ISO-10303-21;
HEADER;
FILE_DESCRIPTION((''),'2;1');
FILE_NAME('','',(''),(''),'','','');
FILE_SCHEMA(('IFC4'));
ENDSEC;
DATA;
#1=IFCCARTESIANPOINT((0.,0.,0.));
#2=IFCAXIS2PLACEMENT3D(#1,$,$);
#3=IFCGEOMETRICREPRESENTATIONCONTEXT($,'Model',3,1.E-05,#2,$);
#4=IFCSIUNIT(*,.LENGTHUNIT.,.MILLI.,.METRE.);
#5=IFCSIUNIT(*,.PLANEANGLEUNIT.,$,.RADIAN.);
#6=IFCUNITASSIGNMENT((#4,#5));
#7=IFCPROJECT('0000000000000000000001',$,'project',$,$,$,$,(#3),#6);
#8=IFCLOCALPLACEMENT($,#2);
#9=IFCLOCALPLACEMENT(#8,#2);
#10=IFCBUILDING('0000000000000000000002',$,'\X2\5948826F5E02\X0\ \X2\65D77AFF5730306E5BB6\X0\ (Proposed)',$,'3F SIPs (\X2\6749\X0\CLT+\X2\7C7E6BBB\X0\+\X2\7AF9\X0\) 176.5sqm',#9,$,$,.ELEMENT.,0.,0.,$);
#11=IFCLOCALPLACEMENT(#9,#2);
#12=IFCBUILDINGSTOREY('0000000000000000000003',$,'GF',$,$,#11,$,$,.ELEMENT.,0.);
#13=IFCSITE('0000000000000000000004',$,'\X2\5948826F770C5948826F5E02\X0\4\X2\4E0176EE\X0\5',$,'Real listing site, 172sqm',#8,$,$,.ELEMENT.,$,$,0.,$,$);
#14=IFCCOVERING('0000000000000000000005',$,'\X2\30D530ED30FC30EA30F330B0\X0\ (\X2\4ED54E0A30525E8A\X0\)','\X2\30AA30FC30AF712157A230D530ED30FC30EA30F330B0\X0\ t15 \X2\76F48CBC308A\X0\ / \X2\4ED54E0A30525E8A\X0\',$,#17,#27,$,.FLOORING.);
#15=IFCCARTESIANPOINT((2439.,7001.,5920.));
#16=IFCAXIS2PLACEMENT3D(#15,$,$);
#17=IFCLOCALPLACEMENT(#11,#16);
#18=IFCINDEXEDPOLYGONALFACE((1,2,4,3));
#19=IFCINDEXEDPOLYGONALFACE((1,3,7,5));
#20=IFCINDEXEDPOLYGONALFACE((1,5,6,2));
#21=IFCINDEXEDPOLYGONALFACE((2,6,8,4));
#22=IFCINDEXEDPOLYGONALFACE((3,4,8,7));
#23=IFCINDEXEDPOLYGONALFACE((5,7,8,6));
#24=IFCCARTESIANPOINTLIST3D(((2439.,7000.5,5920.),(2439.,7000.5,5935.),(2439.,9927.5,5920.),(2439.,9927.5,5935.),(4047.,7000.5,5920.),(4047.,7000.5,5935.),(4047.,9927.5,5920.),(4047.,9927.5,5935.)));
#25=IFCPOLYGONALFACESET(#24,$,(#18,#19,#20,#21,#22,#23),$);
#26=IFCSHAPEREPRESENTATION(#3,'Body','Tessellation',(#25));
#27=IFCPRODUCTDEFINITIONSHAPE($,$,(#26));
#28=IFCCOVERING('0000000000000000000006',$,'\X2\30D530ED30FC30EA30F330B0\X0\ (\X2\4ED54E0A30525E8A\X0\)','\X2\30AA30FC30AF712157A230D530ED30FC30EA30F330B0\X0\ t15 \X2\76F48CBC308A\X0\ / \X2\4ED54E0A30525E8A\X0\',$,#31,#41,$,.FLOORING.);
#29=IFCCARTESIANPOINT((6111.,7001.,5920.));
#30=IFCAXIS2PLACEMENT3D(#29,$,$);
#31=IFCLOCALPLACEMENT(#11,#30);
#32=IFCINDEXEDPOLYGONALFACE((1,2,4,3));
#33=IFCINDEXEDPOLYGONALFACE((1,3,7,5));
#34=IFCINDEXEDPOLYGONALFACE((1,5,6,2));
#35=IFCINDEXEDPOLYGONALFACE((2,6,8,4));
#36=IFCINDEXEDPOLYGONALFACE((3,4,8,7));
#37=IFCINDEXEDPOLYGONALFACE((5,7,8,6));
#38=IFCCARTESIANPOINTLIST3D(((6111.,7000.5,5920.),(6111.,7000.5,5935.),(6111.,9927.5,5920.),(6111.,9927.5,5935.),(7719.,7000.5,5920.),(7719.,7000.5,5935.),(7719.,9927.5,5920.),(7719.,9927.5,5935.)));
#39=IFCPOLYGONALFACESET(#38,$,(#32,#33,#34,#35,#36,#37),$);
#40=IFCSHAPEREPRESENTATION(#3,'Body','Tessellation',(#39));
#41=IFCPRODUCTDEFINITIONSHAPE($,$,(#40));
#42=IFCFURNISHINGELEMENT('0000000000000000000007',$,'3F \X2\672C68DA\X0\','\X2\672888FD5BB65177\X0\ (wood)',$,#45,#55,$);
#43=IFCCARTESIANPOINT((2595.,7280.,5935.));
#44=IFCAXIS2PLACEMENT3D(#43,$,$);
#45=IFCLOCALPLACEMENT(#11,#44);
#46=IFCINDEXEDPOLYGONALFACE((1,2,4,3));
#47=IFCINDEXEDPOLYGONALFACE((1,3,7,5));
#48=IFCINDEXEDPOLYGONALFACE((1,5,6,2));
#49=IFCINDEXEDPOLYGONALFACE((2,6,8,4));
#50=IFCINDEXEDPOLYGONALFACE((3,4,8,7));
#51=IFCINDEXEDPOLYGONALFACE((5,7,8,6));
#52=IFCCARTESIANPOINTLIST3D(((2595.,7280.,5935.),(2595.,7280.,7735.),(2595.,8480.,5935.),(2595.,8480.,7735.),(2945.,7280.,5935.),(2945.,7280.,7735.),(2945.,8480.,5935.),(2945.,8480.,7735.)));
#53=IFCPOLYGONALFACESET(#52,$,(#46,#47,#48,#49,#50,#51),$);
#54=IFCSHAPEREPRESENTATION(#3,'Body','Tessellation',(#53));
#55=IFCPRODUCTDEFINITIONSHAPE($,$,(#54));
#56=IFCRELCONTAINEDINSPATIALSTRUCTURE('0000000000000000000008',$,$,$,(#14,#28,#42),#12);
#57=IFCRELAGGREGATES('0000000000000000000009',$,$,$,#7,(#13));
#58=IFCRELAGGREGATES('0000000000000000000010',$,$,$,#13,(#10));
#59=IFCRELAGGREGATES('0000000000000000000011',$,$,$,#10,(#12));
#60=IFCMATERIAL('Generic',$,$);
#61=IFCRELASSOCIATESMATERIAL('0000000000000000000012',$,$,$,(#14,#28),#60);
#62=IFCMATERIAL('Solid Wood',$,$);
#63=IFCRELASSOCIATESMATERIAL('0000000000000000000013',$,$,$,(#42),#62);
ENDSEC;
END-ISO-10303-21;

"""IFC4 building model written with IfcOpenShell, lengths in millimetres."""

from ifc_helpers import new_model, si_unit, frame, frame_2d, origin, place, context, project, spatial, rectangle, extrude, material, element, save


model = new_model("IFC4")

# Units and contexts
model_context = context("Model", 3, precision=1e-05, world=origin())
ifc_project = project(units=[si_unit("LENGTHUNIT", "METRE", prefix="MILLI"), si_unit("PLANEANGLEUNIT", "RADIAN")], contexts=[model_context])

# Site, building, storey
site_placement = place(None, origin())
site = spatial("IfcSite", under=ifc_project, at=site_placement, Name="奈良県奈良市4丁目5", ObjectType="Real listing site, 172sqm", CompositionType="ELEMENT", RefElevation=0.0)
building_placement = place(site_placement, origin())
building = spatial("IfcBuilding", under=site, at=building_placement, Name="奈良市 旗竿地の家 (Proposed)", ObjectType="3F SIPs (杉CLT+籾殻+竹) 176.5sqm", CompositionType="ELEMENT", ElevationOfRefHeight=0.0, ElevationOfTerrain=0.0)
storey_placement = place(building_placement, origin())
storey = spatial("IfcBuildingStorey", under=building, at=storey_placement, Name="GF", CompositionType="ELEMENT", Elevation=0.0)

# Shared definitions
ifc_material_1 = material(Name="Solid Wood")

# Shared definitions
ifc_material_2 = material(Name="Generic")

# Coverings
covering_1_placement = place(storey_placement, frame((2439.0, 7001.0, 5920.0)))
element("IfcCovering", 1, at=covering_1_placement, inside=storey, material=ifc_material_2, Name="フローリング (仕上げ床)", Description="オーク無垢フローリング t15 直貼り / 仕上げ床", PredefinedType="FLOORING", context=model_context, shape_type="SweptSolid", body=[
    extrude(rectangle(XDim=1608.0, YDim=2927.0, at=frame_2d((804.0, 1463.0))), frame((2439.0, 7001.0, 5920.0)), (0.0, 0.0, 1.0), 15.0),
])
covering_2_placement = place(storey_placement, frame((6111.0, 7001.0, 5920.0)))
element("IfcCovering", 2, at=covering_2_placement, inside=storey, material=ifc_material_2, Name="フローリング (仕上げ床)", Description="オーク無垢フローリング t15 直貼り / 仕上げ床", PredefinedType="FLOORING", context=model_context, shape_type="SweptSolid", body=[
    extrude(rectangle(XDim=1608.0, YDim=2927.0, at=frame_2d((804.0, 1463.0))), frame((6111.0, 7001.0, 5920.0)), (0.0, 0.0, 1.0), 15.0),
])

# Furnishing element
furnishing_placement = place(storey_placement, frame((2595.0, 7280.0, 5935.0)))
element("IfcFurnishingElement", 3, at=furnishing_placement, inside=storey, material=ifc_material_1, Name="3F 本棚", Description="木製家具 (wood)", context=model_context, shape_type="SweptSolid", body=[
    extrude(rectangle(XDim=350.0, YDim=1200.0, at=frame_2d((175.0, 600.0))), frame((2595.0, 7280.0, 5935.0)), (0.0, 0.0, 1.0), 1800.0),
])

save(model, "model.ifc")
